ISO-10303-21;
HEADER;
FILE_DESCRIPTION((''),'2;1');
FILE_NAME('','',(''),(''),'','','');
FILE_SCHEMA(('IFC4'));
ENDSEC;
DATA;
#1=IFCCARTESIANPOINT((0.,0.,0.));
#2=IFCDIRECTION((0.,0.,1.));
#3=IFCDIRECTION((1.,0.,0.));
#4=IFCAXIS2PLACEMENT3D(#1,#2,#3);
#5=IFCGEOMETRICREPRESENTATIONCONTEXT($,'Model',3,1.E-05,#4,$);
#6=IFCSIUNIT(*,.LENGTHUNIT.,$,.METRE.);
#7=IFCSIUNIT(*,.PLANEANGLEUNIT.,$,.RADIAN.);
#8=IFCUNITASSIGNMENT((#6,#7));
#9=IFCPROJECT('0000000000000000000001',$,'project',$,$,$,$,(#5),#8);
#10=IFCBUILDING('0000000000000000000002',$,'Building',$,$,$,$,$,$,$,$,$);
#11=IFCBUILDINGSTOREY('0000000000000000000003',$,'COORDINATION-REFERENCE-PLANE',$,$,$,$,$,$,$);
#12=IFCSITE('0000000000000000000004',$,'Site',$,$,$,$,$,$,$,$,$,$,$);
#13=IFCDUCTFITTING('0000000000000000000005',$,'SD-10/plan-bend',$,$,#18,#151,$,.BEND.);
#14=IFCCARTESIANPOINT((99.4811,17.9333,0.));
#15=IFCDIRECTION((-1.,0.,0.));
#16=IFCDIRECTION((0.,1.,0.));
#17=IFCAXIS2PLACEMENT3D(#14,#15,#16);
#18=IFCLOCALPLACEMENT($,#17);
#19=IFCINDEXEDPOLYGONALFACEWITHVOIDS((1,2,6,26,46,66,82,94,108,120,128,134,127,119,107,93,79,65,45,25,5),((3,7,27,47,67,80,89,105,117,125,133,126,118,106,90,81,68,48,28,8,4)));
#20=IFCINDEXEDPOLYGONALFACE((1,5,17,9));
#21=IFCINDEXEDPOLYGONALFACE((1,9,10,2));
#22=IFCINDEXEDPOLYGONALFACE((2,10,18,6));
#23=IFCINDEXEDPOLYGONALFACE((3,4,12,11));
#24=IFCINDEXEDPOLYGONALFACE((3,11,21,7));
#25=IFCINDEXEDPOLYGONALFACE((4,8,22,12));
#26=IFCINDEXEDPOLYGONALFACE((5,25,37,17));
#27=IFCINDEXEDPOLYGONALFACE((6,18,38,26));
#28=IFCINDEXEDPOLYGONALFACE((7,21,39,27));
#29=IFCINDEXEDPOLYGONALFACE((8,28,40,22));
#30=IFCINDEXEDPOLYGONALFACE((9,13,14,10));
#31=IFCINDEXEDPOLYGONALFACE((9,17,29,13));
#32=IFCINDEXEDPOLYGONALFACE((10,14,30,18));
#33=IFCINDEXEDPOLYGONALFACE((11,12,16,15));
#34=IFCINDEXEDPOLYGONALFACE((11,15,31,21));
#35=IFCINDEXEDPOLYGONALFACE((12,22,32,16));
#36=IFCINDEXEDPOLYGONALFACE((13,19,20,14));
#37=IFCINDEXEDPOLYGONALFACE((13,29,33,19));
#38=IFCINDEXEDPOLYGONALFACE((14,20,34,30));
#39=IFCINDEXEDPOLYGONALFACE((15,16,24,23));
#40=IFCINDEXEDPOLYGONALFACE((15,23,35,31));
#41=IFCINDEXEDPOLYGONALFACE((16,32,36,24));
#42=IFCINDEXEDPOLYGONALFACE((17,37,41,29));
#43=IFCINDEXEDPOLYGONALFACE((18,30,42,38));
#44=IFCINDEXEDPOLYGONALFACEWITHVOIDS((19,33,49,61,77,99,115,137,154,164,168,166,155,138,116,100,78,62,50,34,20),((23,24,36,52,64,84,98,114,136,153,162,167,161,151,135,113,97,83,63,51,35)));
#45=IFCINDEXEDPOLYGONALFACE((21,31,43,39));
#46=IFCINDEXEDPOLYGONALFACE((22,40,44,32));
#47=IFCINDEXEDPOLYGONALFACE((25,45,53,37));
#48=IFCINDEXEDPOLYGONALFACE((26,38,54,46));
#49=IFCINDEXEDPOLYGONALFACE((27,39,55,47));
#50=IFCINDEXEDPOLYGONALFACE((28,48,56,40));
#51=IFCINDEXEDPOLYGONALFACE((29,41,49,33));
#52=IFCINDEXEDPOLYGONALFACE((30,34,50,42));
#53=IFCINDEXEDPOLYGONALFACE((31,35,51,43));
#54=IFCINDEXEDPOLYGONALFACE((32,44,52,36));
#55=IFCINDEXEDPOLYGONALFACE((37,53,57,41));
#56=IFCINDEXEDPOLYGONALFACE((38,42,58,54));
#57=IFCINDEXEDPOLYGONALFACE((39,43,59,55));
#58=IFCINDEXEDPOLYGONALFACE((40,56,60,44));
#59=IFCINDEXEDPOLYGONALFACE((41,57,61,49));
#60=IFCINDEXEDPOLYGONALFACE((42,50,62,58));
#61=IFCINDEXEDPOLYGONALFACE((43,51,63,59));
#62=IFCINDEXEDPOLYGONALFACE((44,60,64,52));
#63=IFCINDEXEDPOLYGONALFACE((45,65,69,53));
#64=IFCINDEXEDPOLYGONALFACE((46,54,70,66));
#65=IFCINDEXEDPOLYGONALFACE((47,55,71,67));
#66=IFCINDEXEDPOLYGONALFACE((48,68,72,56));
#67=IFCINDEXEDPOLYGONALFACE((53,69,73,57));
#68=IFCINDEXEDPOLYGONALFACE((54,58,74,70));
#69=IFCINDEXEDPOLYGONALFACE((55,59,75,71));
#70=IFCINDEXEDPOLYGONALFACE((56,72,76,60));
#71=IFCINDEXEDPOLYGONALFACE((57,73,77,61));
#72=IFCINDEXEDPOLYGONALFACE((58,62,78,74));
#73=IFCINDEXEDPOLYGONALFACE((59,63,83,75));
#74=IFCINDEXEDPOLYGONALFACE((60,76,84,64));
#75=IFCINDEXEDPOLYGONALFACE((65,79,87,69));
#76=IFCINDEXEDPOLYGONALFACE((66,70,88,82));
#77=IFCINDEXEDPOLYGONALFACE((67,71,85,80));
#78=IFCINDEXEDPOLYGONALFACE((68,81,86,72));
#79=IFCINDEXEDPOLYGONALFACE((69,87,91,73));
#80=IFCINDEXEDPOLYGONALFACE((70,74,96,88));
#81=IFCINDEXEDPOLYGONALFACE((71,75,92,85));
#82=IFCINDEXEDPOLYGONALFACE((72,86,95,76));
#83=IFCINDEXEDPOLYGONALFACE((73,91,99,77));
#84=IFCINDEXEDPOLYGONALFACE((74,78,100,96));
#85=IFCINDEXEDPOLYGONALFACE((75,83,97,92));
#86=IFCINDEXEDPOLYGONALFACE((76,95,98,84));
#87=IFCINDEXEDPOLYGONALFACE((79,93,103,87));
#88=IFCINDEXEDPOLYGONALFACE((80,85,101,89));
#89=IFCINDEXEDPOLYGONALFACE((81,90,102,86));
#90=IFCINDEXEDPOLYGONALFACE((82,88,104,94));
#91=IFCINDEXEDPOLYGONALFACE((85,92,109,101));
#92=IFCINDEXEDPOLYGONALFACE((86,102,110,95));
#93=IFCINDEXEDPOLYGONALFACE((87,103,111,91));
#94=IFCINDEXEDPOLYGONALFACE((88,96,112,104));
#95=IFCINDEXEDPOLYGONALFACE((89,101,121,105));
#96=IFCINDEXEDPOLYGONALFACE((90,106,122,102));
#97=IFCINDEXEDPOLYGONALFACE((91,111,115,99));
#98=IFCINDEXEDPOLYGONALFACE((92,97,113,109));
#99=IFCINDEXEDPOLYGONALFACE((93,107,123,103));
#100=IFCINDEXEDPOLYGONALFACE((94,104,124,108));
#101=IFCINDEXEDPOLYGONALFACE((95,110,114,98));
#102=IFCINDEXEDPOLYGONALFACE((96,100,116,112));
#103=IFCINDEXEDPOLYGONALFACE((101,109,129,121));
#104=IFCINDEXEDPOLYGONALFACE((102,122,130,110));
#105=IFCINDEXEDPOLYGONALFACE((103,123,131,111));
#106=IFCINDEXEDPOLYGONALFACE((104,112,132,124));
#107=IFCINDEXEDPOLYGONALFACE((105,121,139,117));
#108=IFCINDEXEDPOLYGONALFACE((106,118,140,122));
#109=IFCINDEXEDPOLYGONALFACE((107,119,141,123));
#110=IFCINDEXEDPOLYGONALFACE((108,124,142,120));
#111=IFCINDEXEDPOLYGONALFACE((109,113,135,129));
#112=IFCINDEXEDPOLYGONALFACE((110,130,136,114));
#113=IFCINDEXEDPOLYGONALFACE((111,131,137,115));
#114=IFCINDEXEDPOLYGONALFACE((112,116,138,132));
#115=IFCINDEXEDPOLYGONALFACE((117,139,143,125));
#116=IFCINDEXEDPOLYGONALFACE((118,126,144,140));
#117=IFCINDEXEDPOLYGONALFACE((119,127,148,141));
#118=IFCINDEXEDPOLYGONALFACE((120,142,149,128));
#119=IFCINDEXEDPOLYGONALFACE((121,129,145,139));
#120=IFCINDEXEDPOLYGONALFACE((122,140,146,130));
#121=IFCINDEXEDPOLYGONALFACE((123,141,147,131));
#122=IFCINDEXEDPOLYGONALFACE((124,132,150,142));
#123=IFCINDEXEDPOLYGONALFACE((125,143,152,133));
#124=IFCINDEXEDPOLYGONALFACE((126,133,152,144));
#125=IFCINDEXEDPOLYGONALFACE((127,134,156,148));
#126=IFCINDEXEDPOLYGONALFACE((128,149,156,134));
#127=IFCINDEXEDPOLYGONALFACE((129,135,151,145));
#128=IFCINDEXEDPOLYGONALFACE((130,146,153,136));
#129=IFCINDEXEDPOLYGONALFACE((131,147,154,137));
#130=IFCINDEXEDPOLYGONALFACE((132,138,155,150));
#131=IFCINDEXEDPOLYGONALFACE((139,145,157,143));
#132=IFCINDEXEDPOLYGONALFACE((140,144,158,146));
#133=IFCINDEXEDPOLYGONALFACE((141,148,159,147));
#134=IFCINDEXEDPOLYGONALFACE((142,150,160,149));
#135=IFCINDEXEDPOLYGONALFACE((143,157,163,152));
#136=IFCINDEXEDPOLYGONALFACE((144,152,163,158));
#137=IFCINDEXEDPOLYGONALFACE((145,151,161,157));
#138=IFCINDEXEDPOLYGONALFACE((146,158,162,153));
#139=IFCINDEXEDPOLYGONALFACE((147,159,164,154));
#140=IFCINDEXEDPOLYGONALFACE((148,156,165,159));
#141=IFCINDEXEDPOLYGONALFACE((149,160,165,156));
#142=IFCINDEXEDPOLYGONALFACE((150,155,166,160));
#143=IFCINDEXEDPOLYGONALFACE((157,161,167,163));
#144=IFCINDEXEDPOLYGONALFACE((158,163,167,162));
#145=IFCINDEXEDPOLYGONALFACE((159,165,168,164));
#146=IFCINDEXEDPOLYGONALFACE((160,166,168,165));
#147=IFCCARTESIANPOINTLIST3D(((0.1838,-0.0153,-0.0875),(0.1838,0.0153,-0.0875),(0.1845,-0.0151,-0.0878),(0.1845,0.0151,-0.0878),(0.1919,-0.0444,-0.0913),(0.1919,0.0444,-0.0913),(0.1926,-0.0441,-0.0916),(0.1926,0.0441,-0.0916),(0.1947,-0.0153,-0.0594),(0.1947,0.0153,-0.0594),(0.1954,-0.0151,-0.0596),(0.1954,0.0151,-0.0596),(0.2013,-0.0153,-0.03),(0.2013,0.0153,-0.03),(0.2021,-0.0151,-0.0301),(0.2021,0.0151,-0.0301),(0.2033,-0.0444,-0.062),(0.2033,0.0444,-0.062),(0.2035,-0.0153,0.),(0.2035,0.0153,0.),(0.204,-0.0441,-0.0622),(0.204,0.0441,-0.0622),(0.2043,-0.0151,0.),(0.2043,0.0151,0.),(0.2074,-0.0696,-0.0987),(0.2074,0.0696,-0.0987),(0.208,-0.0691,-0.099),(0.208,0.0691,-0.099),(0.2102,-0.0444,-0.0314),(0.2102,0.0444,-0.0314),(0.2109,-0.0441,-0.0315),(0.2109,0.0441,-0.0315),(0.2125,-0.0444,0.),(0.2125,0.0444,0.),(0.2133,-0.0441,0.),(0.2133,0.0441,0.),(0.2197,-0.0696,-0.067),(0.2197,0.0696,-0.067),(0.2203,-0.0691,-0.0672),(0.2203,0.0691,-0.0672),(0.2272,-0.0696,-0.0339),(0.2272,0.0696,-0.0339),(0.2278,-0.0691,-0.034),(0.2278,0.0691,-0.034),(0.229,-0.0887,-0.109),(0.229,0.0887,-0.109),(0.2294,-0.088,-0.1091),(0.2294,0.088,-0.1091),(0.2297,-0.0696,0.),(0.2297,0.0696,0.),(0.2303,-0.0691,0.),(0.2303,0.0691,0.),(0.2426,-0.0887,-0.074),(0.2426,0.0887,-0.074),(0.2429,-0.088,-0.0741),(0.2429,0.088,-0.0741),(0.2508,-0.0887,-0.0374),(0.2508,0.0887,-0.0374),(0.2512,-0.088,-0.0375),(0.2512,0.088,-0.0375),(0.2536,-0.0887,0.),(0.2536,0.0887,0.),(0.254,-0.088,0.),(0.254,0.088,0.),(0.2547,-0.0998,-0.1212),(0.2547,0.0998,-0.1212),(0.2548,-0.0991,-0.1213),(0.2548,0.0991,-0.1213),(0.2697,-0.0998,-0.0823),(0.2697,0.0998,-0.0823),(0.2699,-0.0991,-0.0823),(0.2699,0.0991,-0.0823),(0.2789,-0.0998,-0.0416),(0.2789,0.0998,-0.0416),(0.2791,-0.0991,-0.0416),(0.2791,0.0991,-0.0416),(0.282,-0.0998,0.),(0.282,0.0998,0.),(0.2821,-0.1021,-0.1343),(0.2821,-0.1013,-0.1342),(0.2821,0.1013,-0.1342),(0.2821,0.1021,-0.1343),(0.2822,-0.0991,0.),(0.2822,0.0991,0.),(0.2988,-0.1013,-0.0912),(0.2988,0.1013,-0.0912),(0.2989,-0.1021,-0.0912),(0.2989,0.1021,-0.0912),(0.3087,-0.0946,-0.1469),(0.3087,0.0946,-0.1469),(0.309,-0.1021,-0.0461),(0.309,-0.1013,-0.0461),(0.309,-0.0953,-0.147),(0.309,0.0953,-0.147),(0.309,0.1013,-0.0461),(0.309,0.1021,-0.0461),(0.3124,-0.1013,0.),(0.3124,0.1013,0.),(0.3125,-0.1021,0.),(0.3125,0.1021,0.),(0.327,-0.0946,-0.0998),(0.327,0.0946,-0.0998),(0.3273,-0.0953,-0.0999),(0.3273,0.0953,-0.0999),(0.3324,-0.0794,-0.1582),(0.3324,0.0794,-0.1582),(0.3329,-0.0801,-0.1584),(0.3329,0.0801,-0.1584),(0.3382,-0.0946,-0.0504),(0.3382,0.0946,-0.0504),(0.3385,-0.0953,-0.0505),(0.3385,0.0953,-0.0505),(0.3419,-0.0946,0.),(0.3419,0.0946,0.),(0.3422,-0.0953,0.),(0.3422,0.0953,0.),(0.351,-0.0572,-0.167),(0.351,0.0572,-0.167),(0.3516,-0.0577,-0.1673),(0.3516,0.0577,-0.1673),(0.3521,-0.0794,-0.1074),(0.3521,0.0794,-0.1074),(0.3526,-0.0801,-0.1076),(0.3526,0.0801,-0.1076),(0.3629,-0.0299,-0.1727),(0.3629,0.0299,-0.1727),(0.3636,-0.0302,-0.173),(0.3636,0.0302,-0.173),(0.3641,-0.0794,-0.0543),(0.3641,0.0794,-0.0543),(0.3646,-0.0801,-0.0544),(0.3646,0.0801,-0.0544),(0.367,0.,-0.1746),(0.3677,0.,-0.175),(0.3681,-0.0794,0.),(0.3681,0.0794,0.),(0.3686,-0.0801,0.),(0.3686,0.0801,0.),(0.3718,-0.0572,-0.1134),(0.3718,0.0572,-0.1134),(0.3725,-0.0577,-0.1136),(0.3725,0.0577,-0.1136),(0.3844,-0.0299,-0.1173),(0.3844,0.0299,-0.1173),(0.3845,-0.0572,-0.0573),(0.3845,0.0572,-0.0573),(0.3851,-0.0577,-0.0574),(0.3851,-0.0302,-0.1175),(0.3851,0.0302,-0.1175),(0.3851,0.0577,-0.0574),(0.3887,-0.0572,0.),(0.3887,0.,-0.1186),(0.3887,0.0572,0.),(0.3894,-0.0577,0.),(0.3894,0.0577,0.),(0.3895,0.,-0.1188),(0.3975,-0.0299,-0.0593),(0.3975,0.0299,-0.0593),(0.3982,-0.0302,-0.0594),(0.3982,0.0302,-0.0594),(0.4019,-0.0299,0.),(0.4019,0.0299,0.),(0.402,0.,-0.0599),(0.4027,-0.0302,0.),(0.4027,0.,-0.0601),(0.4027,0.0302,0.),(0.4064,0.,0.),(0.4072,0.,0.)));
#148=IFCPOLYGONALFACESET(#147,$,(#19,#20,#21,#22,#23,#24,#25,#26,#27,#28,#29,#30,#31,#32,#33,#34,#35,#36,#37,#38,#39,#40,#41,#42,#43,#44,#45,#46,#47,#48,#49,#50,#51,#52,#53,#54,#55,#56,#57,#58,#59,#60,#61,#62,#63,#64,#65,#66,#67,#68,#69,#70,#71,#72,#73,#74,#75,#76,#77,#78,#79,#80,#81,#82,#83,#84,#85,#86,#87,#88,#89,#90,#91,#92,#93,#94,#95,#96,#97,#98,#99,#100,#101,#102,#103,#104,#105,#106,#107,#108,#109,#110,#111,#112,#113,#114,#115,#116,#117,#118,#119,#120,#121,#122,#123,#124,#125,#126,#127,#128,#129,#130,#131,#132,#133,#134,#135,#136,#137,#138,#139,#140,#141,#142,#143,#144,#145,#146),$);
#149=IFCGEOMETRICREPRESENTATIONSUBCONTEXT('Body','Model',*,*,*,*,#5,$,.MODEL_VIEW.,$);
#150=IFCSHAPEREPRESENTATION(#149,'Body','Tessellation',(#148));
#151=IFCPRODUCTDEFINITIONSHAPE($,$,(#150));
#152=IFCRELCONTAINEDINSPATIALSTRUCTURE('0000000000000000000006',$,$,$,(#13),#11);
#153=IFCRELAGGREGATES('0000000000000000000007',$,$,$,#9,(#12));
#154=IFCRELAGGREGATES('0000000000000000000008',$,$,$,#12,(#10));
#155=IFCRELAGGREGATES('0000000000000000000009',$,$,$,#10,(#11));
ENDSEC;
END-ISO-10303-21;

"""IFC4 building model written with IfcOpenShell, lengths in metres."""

from ifc_helpers import new_model, entity, si_unit, frame, origin_with_axes, place, context, subcontext, project, spatial, element, save


model = new_model("IFC4")

# Units and contexts
model_context = context("Model", 3, precision=1e-05, world=origin_with_axes())
body_context_1 = subcontext(model_context, "Body", "Model", "MODEL_VIEW")
ifc_project = project(units=[si_unit("LENGTHUNIT", "METRE"), si_unit("PLANEANGLEUNIT", "RADIAN")], contexts=[model_context])

# Site, building, storey
site = spatial("IfcSite", under=ifc_project, Name="Site")
building = spatial("IfcBuilding", under=site, Name="Building")
storey = spatial("IfcBuildingStorey", under=building, Name="COORDINATION-REFERENCE-PLANE")

# Duct fitting
duct_fitting_1_placement = place(None, frame((99.4811, 17.9333, 0.0), z_axis=(-1.0, 0.0, 0.0), x_axis=(0.0, 1.0, 0.0)))
element("IfcDuctFitting", 1, at=duct_fitting_1_placement, inside=storey, Name="SD-10/plan-bend", PredefinedType="BEND", context=body_context_1, shape_type="SweptSolid", body=[
    entity("IfcRevolvedAreaSolid", entity("IfcCircleHollowProfileDef", "AREA", None, entity("IfcAxis2Placement2D", entity("IfcCartesianPoint", [0.3048, 0.0])), 0.1024, 0.0008), entity("IfcAxis2Placement3D", entity("IfcCartesianPoint", [0.0, 0.0, 0.0]), entity("IfcDirection", [0.0, 0.0, 1.0]), entity("IfcDirection", [1.0, 0.0, 0.0])), entity("IfcAxis1Placement", entity("IfcCartesianPoint", [0.0, 0.0, 0.0]), entity("IfcDirection", [0.0, 1.0, 0.0])), 0.444153),
])

save(model, "model.ifc")
